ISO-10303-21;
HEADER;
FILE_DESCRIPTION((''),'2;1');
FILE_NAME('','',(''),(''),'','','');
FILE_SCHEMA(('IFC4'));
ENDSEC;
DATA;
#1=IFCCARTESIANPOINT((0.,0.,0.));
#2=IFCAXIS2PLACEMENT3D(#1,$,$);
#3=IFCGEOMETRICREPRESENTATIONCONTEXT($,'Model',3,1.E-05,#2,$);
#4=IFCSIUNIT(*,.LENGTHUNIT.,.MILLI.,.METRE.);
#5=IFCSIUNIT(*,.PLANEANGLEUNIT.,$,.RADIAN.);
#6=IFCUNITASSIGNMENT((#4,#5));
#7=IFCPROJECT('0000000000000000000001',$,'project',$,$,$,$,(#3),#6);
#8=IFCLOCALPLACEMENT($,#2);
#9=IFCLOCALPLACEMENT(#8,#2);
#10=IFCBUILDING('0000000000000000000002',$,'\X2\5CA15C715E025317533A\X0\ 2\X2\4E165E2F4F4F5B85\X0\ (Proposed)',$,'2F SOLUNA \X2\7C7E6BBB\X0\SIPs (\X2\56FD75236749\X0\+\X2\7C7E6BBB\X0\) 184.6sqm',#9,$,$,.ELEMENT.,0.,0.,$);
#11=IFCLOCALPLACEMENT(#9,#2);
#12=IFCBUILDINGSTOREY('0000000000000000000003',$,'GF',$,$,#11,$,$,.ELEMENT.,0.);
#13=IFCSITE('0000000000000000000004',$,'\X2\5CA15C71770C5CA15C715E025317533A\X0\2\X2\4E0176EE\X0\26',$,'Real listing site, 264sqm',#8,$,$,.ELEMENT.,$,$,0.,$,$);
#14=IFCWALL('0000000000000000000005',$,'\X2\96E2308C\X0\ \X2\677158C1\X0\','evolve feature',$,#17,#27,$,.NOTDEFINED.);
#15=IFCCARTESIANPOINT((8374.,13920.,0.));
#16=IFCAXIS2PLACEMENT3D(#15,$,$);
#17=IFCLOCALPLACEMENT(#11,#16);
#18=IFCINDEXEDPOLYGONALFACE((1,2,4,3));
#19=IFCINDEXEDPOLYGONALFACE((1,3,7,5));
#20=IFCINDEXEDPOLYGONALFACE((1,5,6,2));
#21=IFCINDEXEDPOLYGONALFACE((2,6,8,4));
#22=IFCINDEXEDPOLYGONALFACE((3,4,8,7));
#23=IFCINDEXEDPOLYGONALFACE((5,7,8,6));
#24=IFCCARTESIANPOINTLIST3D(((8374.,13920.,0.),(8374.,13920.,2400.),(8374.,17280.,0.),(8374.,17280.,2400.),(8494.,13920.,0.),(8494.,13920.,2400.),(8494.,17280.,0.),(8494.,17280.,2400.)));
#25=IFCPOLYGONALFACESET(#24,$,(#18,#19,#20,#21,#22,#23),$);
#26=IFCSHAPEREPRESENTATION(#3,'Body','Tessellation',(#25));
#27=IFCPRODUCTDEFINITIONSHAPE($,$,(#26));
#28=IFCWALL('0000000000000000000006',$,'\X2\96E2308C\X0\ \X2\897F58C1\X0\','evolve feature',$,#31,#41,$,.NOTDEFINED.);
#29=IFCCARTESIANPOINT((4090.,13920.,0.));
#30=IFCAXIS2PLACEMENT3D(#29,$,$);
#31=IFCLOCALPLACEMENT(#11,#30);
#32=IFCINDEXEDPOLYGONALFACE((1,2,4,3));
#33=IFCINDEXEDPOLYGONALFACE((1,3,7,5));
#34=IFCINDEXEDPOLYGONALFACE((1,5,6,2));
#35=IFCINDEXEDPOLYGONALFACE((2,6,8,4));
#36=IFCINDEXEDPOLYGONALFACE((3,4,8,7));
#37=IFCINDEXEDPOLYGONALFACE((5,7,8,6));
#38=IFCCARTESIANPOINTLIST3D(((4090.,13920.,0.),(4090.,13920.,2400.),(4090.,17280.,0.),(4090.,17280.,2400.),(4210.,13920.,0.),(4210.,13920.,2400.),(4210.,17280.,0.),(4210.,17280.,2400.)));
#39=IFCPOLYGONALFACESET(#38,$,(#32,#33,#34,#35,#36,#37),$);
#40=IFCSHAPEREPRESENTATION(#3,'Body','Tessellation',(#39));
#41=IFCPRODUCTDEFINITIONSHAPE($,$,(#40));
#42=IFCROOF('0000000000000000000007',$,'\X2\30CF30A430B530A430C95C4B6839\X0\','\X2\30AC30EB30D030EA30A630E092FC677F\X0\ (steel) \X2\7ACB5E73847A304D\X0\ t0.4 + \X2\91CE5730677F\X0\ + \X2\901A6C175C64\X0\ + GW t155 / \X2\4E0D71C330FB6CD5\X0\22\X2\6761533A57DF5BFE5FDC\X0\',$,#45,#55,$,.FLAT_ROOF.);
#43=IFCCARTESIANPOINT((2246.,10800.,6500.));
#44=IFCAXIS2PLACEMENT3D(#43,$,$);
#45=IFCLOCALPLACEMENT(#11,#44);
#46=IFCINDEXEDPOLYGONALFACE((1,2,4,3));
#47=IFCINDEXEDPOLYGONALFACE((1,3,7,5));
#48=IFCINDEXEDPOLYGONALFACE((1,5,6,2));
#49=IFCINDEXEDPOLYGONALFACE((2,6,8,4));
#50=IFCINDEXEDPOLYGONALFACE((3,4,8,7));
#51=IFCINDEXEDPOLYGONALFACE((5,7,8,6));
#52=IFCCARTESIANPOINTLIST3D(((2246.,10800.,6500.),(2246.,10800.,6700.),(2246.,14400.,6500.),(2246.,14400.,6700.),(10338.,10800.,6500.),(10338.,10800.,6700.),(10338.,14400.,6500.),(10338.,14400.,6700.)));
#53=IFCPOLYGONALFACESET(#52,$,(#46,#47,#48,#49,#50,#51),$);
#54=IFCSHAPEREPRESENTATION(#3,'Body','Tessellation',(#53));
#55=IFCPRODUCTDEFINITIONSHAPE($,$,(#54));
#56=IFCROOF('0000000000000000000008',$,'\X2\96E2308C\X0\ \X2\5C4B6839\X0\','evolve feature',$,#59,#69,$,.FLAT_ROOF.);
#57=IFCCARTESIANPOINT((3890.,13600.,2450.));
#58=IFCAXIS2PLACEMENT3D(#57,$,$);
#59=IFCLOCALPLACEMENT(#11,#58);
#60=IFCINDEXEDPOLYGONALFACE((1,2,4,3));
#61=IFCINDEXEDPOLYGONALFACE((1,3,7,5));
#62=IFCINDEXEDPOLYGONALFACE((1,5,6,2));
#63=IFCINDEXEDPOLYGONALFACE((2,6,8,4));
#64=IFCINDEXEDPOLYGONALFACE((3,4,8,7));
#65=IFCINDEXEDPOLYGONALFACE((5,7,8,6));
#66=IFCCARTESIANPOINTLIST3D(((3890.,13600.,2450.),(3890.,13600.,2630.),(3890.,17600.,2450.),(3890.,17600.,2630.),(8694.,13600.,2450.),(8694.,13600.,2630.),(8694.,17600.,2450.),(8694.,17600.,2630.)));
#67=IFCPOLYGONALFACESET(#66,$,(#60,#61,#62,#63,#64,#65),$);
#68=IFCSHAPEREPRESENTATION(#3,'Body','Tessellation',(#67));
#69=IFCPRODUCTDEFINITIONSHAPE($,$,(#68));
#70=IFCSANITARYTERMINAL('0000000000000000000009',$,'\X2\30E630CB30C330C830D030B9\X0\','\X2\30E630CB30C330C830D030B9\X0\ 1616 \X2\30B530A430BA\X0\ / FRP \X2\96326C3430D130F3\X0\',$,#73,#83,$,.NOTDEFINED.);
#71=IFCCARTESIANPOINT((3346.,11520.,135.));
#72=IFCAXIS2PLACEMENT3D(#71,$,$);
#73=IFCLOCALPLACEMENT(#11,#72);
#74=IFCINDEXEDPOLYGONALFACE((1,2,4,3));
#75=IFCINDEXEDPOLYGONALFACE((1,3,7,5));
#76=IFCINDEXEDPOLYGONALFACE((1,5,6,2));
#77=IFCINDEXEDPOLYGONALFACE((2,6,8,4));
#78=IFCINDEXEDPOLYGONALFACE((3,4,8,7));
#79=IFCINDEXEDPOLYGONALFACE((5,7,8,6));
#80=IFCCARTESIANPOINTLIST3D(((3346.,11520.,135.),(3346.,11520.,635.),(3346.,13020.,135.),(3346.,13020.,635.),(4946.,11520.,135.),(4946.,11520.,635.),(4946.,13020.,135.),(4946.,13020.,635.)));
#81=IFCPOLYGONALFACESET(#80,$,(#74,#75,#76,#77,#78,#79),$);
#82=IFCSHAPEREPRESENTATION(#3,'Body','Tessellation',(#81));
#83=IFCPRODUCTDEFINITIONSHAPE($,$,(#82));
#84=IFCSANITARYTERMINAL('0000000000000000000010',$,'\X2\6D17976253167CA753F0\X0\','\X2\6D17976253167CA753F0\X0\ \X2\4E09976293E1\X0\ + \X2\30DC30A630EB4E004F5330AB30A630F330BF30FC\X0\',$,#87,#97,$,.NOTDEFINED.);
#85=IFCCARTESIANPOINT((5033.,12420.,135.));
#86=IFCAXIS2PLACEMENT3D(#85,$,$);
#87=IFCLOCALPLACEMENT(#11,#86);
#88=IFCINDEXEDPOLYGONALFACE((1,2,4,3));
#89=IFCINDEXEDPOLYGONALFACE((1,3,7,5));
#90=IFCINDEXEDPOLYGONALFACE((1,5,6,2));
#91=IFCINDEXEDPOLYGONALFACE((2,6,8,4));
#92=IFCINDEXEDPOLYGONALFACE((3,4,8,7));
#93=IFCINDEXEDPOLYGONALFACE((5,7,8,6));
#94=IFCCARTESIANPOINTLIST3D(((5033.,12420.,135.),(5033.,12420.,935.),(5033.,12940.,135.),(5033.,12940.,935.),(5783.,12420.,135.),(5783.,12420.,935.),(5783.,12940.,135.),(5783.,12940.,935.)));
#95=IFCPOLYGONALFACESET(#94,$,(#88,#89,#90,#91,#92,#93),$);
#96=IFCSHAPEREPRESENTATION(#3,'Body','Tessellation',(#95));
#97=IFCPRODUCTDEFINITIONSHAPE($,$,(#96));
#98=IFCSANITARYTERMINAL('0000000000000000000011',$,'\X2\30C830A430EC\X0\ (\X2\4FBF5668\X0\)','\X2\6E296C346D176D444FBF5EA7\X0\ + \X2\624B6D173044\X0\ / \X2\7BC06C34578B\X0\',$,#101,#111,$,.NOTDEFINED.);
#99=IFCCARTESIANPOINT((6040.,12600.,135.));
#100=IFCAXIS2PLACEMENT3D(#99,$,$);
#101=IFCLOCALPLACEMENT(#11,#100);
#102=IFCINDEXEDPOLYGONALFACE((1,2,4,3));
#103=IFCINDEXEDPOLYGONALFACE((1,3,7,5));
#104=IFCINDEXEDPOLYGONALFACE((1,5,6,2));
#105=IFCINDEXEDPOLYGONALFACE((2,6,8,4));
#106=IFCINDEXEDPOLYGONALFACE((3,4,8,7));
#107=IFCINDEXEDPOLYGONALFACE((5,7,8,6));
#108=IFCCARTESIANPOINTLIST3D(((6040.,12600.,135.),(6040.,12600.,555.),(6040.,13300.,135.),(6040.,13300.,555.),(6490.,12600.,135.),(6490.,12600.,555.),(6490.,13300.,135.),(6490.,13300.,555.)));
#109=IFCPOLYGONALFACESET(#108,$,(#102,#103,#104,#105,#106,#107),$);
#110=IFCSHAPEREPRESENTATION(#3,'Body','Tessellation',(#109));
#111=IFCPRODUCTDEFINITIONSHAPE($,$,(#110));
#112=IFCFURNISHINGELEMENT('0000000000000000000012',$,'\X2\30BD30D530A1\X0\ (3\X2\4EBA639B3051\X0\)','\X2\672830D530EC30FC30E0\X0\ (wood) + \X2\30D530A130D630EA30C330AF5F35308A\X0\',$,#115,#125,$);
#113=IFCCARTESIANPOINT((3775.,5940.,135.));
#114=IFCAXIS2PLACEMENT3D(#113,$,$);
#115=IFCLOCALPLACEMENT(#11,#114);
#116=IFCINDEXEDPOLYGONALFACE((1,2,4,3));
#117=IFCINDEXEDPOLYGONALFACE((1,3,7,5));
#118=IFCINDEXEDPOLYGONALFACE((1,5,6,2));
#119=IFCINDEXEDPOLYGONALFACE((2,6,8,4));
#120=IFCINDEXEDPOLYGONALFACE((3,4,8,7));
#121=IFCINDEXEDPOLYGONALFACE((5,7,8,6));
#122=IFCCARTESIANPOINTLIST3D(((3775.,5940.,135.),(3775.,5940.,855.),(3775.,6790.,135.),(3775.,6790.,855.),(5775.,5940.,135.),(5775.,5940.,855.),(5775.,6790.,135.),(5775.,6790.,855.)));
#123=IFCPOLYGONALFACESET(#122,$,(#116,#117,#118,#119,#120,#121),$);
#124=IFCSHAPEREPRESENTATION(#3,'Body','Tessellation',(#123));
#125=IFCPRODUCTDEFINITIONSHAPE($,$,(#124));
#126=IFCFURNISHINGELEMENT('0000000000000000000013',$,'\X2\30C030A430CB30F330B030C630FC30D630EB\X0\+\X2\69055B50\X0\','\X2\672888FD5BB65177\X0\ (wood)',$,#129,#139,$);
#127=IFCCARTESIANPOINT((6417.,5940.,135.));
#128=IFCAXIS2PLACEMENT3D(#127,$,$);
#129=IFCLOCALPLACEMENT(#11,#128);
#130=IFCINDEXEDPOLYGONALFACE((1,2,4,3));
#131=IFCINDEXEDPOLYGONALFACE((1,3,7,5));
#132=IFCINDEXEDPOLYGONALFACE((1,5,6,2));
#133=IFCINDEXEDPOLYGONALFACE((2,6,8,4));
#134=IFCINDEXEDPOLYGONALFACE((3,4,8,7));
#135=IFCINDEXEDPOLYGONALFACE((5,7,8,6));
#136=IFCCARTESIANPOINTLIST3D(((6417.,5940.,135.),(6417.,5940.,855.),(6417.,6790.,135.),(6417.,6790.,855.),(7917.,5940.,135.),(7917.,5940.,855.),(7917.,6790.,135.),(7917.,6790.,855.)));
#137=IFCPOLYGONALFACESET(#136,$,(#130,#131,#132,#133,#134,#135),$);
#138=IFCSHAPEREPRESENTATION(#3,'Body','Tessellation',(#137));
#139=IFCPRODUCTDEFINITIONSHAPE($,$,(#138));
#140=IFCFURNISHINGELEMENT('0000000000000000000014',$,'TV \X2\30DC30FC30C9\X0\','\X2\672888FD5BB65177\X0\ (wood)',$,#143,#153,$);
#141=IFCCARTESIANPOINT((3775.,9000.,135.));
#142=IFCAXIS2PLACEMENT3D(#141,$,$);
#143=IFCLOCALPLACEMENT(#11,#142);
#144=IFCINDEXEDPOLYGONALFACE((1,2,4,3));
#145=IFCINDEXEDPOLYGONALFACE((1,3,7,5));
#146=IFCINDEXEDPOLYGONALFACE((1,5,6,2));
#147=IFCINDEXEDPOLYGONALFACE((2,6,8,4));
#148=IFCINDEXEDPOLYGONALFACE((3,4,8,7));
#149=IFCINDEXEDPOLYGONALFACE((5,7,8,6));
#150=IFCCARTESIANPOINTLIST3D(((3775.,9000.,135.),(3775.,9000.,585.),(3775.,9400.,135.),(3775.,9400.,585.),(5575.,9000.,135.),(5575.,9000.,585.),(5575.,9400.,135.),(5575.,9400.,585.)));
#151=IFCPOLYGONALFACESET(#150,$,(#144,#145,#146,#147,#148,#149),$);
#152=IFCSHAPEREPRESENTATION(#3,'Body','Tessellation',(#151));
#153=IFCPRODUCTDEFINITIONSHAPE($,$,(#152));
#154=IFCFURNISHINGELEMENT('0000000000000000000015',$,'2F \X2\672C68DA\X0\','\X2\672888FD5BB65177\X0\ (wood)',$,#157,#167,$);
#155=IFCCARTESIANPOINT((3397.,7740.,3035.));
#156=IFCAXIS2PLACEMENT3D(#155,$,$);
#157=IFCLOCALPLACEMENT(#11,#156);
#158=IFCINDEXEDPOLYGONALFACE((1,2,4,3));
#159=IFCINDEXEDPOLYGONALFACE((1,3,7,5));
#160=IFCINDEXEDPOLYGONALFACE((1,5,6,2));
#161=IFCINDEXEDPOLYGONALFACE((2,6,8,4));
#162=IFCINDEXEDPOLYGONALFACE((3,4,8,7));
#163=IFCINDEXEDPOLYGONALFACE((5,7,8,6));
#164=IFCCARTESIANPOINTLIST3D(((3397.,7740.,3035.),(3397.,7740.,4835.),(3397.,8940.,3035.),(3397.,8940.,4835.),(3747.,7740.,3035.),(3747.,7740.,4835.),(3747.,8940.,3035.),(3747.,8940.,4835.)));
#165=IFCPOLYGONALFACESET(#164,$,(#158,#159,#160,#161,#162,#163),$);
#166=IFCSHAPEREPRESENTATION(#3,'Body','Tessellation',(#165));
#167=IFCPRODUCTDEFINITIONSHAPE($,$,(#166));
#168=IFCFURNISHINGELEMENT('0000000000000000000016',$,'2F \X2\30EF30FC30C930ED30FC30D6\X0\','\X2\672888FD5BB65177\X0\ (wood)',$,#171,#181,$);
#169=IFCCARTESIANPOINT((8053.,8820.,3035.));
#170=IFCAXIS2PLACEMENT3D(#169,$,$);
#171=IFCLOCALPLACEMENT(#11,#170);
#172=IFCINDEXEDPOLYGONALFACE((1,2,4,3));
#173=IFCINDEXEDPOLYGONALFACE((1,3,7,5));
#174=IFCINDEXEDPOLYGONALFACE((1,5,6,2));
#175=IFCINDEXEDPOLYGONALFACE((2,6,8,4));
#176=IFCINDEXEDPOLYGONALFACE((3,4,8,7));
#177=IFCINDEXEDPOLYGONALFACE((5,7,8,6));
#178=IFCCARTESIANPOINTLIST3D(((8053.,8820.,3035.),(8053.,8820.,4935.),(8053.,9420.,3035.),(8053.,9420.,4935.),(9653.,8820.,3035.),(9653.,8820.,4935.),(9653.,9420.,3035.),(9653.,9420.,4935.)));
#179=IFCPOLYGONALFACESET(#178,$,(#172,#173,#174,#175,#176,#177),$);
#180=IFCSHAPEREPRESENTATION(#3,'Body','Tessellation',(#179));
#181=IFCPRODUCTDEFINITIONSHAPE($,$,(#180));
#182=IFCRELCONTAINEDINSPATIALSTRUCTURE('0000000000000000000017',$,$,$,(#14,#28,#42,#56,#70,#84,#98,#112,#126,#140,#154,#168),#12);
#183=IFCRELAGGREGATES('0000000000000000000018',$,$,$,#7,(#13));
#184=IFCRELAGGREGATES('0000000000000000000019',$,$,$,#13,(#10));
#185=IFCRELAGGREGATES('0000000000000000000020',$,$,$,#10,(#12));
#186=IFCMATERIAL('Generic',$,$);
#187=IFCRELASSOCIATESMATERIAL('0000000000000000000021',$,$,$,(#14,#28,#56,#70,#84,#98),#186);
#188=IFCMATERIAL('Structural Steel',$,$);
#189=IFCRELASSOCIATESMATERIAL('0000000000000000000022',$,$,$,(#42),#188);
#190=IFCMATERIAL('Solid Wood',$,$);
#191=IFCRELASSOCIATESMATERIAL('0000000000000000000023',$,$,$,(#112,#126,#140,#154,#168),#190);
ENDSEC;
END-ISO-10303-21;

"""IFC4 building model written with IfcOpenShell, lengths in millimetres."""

from ifc_helpers import new_model, si_unit, frame, frame_2d, origin, place, context, project, spatial, rectangle, extrude, material, element, save


model = new_model("IFC4")

# Units and contexts
model_context = context("Model", 3, precision=1e-05, world=origin())
ifc_project = project(units=[si_unit("LENGTHUNIT", "METRE", prefix="MILLI"), si_unit("PLANEANGLEUNIT", "RADIAN")], contexts=[model_context])

# Site, building, storey
site_placement = place(None, origin())
site = spatial("IfcSite", under=ifc_project, at=site_placement, Name="岡山県岡山市北区2丁目26", ObjectType="Real listing site, 264sqm", CompositionType="ELEMENT", RefElevation=0.0)
building_placement = place(site_placement, origin())
building = spatial("IfcBuilding", under=site, at=building_placement, Name="岡山市北区 2世帯住宅 (Proposed)", ObjectType="2F SOLUNA 籾殻SIPs (国産杉+籾殻) 184.6sqm", CompositionType="ELEMENT", ElevationOfRefHeight=0.0, ElevationOfTerrain=0.0)
storey_placement = place(building_placement, origin())
storey = spatial("IfcBuildingStorey", under=building, at=storey_placement, Name="GF", CompositionType="ELEMENT", Elevation=0.0)

# Shared definitions
ifc_material_1 = material(Name="Generic")

# Shared definitions
ifc_material_2 = material(Name="Solid Wood")

# Walls
wall_1_placement = place(storey_placement, frame((8374.0, 13920.0, 0.0)))
element("IfcWall", 1, at=wall_1_placement, inside=storey, material=ifc_material_1, Name="離れ 東壁", Description="evolve feature", PredefinedType="NOTDEFINED", context=model_context, shape_type="SweptSolid", body=[
    extrude(rectangle(XDim=120.0, YDim=3360.0, at=frame_2d((60.0, 1680.0))), frame((8374.0, 13920.0, 0.0)), (0.0, 0.0, 1.0), 2400.0),
])
wall_2_placement = place(storey_placement, frame((4090.0, 13920.0, 0.0)))
element("IfcWall", 2, at=wall_2_placement, inside=storey, material=ifc_material_1, Name="離れ 西壁", Description="evolve feature", PredefinedType="NOTDEFINED", context=model_context, shape_type="SweptSolid", body=[
    extrude(rectangle(XDim=120.0, YDim=3360.0, at=frame_2d((60.0, 1680.0))), frame((4090.0, 13920.0, 0.0)), (0.0, 0.0, 1.0), 2400.0),
])

# Roofs
ifc_material_3 = material(Name="Structural Steel")
roof_1_placement = place(storey_placement, frame((2246.0, 10800.0, 6500.0)))
element("IfcRoof", 3, at=roof_1_placement, inside=storey, material=ifc_material_3, Name="ハイサイド屋根", Description="ガルバリウム鋼板 (steel) 立平葺き t0.4 + 野地板 + 通気層 + GW t155 / 不燃・法22条区域対応", PredefinedType="FLAT_ROOF", context=model_context, shape_type="SweptSolid", body=[
    extrude(rectangle(XDim=8092.0, YDim=3600.0, at=frame_2d((4046.0, 1800.0))), frame((2246.0, 10800.0, 6500.0)), (0.0, 0.0, 1.0), 200.0),
])
roof_2_placement = place(storey_placement, frame((3890.0, 13600.0, 2450.0)))
element("IfcRoof", 4, at=roof_2_placement, inside=storey, material=ifc_material_1, Name="離れ 屋根", Description="evolve feature", PredefinedType="FLAT_ROOF", context=model_context, shape_type="SweptSolid", body=[
    extrude(rectangle(XDim=4804.0, YDim=4000.0, at=frame_2d((2402.0, 2000.0))), frame((3890.0, 13600.0, 2450.0)), (0.0, 0.0, 1.0), 180.0),
])

# Sanitary terminals
sanitary_terminal_1_placement = place(storey_placement, frame((3346.0, 11520.0, 135.0)))
element("IfcSanitaryTerminal", 5, at=sanitary_terminal_1_placement, inside=storey, material=ifc_material_1, Name="ユニットバス", Description="ユニットバス 1616 サイズ / FRP 防水パン", PredefinedType="NOTDEFINED", context=model_context, shape_type="SweptSolid", body=[
    extrude(rectangle(XDim=1600.0, YDim=1500.0, at=frame_2d((800.0, 750.0))), frame((3346.0, 11520.0, 135.0)), (0.0, 0.0, 1.0), 500.0),
])
sanitary_terminal_2_placement = place(storey_placement, frame((5033.0, 12420.0, 135.0)))
element("IfcSanitaryTerminal", 6, at=sanitary_terminal_2_placement, inside=storey, material=ifc_material_1, Name="洗面化粧台", Description="洗面化粧台 三面鏡 + ボウル一体カウンター", PredefinedType="NOTDEFINED", context=model_context, shape_type="SweptSolid", body=[
    extrude(rectangle(XDim=750.0, YDim=520.0, at=frame_2d((375.0, 260.0))), frame((5033.0, 12420.0, 135.0)), (0.0, 0.0, 1.0), 800.0),
])
sanitary_terminal_3_placement = place(storey_placement, frame((6040.0, 12600.0, 135.0)))
element("IfcSanitaryTerminal", 7, at=sanitary_terminal_3_placement, inside=storey, material=ifc_material_1, Name="トイレ (便器)", Description="温水洗浄便座 + 手洗い / 節水型", PredefinedType="NOTDEFINED", context=model_context, shape_type="SweptSolid", body=[
    extrude(rectangle(XDim=450.0, YDim=700.0, at=frame_2d((225.0, 350.0))), frame((6040.0, 12600.0, 135.0)), (0.0, 0.0, 1.0), 420.0),
])

# Furnishing elements
furnishing_1_placement = place(storey_placement, frame((3775.0, 5940.0, 135.0)))
element("IfcFurnishingElement", 8, at=furnishing_1_placement, inside=storey, material=ifc_material_2, Name="ソファ (3人掛け)", Description="木フレーム (wood) + ファブリック張り", context=model_context, shape_type="SweptSolid", body=[
    extrude(rectangle(XDim=2000.0, YDim=850.0, at=frame_2d((1000.0, 425.0))), frame((3775.0, 5940.0, 135.0)), (0.0, 0.0, 1.0), 720.0),
])
furnishing_2_placement = place(storey_placement, frame((6417.0, 5940.0, 135.0)))
element("IfcFurnishingElement", 9, at=furnishing_2_placement, inside=storey, material=ifc_material_2, Name="ダイニングテーブル+椅子", Description="木製家具 (wood)", context=model_context, shape_type="SweptSolid", body=[
    extrude(rectangle(XDim=1500.0, YDim=850.0, at=frame_2d((750.0, 425.0))), frame((6417.0, 5940.0, 135.0)), (0.0, 0.0, 1.0), 720.0),
])
furnishing_3_placement = place(storey_placement, frame((3775.0, 9000.0, 135.0)))
element("IfcFurnishingElement", 10, at=furnishing_3_placement, inside=storey, material=ifc_material_2, Name="TV ボード", Description="木製家具 (wood)", context=model_context, shape_type="SweptSolid", body=[
    extrude(rectangle(XDim=1800.0, YDim=400.0, at=frame_2d((900.0, 200.0))), frame((3775.0, 9000.0, 135.0)), (0.0, 0.0, 1.0), 450.0),
])
furnishing_4_placement = place(storey_placement, frame((3397.0, 7740.0, 3035.0)))
element("IfcFurnishingElement", 11, at=furnishing_4_placement, inside=storey, material=ifc_material_2, Name="2F 本棚", Description="木製家具 (wood)", context=model_context, shape_type="SweptSolid", body=[
    extrude(rectangle(XDim=350.0, YDim=1200.0, at=frame_2d((175.0, 600.0))), frame((3397.0, 7740.0, 3035.0)), (0.0, 0.0, 1.0), 1800.0),
])
furnishing_5_placement = place(storey_placement, frame((8053.0, 8820.0, 3035.0)))
element("IfcFurnishingElement", 12, at=furnishing_5_placement, inside=storey, material=ifc_material_2, Name="2F ワードローブ", Description="木製家具 (wood)", context=model_context, shape_type="SweptSolid", body=[
    extrude(rectangle(XDim=1600.0, YDim=600.0, at=frame_2d((800.0, 300.0))), frame((8053.0, 8820.0, 3035.0)), (0.0, 0.0, 1.0), 1900.0),
])

save(model, "model.ifc")
